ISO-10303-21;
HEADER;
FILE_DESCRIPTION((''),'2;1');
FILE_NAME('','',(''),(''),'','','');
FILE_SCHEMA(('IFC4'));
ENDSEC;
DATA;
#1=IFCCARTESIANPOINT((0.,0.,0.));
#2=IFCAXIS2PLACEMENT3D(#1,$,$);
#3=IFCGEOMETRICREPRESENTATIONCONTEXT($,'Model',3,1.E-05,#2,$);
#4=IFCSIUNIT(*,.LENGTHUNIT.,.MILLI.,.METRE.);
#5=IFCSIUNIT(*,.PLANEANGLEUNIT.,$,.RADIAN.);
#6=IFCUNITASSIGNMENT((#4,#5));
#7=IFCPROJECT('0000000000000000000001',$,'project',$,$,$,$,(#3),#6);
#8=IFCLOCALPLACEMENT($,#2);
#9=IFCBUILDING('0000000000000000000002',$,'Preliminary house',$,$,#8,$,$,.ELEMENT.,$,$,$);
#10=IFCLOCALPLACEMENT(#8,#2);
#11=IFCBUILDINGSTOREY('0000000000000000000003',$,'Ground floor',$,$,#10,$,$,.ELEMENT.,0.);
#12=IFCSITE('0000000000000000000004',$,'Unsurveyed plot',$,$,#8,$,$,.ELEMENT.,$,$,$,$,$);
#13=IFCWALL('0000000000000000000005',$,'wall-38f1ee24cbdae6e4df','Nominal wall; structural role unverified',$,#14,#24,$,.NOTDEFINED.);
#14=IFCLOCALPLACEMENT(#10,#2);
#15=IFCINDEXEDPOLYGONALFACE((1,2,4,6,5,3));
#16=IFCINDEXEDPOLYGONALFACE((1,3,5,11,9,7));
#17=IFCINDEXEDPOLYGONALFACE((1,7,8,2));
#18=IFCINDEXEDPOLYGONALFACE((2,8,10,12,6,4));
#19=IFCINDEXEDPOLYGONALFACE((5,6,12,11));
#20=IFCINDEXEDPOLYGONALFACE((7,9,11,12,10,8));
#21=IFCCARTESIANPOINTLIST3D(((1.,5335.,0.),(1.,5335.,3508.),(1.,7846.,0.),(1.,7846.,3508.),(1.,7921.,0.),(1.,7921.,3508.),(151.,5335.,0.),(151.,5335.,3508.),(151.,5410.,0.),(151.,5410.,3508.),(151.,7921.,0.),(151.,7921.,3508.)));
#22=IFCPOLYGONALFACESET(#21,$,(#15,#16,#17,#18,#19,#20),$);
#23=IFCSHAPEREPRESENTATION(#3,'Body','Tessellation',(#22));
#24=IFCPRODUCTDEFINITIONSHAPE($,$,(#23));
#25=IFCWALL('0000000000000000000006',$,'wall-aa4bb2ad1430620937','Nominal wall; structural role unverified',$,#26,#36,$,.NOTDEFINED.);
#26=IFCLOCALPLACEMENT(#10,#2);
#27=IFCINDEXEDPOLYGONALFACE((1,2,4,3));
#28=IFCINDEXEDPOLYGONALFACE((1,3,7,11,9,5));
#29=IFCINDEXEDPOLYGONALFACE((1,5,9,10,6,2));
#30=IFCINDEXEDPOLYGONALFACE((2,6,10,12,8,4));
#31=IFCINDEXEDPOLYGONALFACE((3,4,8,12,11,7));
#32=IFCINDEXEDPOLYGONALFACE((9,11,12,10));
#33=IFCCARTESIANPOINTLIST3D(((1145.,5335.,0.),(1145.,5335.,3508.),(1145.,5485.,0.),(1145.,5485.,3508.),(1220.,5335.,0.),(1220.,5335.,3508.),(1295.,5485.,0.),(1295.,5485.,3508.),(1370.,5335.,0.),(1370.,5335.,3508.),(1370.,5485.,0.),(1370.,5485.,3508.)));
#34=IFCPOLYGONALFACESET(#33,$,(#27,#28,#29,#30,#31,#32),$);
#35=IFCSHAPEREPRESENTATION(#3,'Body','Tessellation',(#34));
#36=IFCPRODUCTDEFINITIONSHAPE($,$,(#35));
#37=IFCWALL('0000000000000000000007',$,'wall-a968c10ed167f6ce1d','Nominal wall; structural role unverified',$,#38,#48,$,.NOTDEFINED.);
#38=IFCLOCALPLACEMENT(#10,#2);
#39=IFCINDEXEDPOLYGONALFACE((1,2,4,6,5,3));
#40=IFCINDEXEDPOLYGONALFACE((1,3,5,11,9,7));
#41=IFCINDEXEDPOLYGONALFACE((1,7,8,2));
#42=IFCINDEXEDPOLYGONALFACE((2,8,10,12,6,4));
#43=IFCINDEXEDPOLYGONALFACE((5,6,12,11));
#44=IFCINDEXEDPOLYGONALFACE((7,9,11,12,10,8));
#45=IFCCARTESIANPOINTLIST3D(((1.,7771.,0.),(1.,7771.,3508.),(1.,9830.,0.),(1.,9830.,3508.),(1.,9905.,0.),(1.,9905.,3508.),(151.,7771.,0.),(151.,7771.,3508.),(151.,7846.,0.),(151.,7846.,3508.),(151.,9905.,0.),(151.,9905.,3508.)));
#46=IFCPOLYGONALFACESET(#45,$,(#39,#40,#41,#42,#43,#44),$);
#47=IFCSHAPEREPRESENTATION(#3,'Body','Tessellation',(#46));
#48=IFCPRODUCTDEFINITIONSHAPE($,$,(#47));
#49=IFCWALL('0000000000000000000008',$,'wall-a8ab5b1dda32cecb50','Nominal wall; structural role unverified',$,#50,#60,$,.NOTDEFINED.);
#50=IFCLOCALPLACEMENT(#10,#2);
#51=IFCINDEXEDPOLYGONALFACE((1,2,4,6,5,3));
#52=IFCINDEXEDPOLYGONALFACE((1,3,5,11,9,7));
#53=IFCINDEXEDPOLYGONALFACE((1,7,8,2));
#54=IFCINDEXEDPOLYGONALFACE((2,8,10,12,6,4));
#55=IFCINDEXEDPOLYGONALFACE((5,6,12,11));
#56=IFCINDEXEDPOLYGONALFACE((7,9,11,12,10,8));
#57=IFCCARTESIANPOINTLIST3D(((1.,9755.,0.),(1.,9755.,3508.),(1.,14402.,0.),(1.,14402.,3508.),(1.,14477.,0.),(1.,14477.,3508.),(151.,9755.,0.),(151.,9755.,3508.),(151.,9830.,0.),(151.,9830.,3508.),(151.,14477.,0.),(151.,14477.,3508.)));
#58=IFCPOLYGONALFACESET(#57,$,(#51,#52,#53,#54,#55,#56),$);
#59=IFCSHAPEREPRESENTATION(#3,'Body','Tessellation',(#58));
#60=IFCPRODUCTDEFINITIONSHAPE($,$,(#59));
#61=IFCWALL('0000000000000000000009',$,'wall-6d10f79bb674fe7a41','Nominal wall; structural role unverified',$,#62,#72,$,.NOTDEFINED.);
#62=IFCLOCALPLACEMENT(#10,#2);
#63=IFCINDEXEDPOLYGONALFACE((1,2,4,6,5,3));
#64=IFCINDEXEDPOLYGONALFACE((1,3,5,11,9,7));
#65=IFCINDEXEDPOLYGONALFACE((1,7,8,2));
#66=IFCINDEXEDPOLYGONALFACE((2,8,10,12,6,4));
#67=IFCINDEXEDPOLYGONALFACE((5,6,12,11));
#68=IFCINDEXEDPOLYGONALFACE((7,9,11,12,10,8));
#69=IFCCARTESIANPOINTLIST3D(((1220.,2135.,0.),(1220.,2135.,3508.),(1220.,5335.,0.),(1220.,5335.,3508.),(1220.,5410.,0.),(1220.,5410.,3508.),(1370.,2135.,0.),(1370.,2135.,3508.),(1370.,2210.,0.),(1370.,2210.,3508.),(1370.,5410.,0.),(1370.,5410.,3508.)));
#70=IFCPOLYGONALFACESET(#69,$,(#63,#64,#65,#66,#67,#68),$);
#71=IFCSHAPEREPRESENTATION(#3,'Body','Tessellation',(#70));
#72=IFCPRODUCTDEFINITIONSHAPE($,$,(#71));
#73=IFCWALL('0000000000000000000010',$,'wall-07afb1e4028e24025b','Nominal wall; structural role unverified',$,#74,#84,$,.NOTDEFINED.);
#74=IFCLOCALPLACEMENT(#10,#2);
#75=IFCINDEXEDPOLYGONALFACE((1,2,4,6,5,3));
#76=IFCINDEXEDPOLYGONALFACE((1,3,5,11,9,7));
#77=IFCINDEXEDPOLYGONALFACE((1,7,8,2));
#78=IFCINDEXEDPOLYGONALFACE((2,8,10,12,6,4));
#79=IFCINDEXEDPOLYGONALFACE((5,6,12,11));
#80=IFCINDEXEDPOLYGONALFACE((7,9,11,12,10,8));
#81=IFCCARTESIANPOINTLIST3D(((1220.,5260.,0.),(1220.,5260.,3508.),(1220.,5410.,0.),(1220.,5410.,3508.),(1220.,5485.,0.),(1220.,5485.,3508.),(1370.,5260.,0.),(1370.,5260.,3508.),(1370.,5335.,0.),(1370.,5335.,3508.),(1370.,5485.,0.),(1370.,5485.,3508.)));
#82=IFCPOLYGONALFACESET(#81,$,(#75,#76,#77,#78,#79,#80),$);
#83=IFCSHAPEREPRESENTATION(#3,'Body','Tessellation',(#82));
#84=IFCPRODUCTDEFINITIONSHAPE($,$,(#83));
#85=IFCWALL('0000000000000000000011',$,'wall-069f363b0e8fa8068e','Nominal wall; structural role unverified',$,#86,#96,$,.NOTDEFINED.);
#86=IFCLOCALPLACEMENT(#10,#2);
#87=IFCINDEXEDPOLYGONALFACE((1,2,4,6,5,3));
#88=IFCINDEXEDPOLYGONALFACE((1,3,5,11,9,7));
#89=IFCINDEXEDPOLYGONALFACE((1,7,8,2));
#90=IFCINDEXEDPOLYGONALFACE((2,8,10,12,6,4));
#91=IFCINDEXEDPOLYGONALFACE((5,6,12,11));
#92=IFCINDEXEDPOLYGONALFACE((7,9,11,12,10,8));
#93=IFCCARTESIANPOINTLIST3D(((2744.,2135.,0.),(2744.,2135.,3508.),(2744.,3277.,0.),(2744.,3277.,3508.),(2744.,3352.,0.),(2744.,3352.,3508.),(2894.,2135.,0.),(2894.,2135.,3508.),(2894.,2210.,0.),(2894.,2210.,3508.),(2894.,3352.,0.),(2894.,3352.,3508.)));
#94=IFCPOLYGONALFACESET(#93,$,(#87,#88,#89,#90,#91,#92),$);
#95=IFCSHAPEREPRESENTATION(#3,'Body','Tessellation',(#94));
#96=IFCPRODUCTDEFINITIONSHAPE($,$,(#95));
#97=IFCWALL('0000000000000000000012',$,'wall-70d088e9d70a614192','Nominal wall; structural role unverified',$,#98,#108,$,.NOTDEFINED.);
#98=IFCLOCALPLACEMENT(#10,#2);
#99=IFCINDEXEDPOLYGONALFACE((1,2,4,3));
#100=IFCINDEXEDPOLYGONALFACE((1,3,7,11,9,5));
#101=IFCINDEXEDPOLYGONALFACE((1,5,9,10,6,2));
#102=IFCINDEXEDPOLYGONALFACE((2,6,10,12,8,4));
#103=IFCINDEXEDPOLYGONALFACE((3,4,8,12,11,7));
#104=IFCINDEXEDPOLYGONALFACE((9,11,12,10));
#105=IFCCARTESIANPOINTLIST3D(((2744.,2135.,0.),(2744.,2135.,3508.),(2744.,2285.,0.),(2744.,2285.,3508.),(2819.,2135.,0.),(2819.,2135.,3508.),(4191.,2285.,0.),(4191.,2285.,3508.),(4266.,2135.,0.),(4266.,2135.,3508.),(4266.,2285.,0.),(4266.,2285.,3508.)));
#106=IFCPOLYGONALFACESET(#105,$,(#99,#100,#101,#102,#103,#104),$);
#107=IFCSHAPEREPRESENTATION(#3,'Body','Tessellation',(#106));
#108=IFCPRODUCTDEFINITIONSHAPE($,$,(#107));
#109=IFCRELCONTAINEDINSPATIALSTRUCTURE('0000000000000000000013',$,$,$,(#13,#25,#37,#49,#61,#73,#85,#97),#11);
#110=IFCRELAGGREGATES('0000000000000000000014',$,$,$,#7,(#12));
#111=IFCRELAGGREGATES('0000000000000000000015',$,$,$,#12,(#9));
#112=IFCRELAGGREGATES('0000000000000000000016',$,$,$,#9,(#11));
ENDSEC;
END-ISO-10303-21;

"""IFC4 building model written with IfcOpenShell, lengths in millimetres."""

from ifc_helpers import new_model, si_unit, origin, place, context, project, spatial, polyline, outline, extrude, element, save


model = new_model("IFC4")

# Units and contexts
model_context = context("Model", 3, precision=1e-05, world=origin())
ifc_project = project(units=[si_unit("LENGTHUNIT", "METRE", prefix="MILLI"), si_unit("PLANEANGLEUNIT", "RADIAN")], contexts=[model_context])

# Site, building, storey
placement_1 = place(None, origin())
site = spatial("IfcSite", under=ifc_project, at=placement_1, Name="Unsurveyed plot", CompositionType="ELEMENT")
building = spatial("IfcBuilding", under=site, at=placement_1, Name="Preliminary house", CompositionType="ELEMENT")
placement_2 = place(placement_1, origin())
storey = spatial("IfcBuildingStorey", under=building, at=placement_2, Name="Ground floor", CompositionType="ELEMENT", Elevation=0.0)

# Wall
element("IfcWall", 1, at=placement_2, inside=storey, Name="wall-38f1ee24cbdae6e4df", Description="Nominal wall; structural role unverified", PredefinedType="NOTDEFINED", context=model_context, shape_type="SweptSolid", body=[
    extrude(outline(polyline([(1.0, 7846.0), (1.0, 7921.0), (151.0, 7921.0), (151.0, 5410.0), (151.0, 5335.0), (1.0, 5335.0), (1.0, 7846.0)])), origin(), (0.0, 0.0, 1.0), 3508.0),
])

# Walls
element("IfcWall", 2, at=placement_2, inside=storey, Name="wall-aa4bb2ad1430620937", Description="Nominal wall; structural role unverified", PredefinedType="NOTDEFINED", context=model_context, shape_type="SweptSolid", body=[
    extrude(outline(polyline([(1295.0, 5485.0), (1370.0, 5485.0), (1370.0, 5335.0), (1220.0, 5335.0), (1145.0, 5335.0), (1145.0, 5485.0), (1295.0, 5485.0)])), origin(), (0.0, 0.0, 1.0), 3508.0),
])
element("IfcWall", 3, at=placement_2, inside=storey, Name="wall-a968c10ed167f6ce1d", Description="Nominal wall; structural role unverified", PredefinedType="NOTDEFINED", context=model_context, shape_type="SweptSolid", body=[
    extrude(outline(polyline([(1.0, 9830.0), (1.0, 9905.0), (151.0, 9905.0), (151.0, 7846.0), (151.0, 7771.0), (1.0, 7771.0), (1.0, 9830.0)])), origin(), (0.0, 0.0, 1.0), 3508.0),
])

# Wall
element("IfcWall", 4, at=placement_2, inside=storey, Name="wall-a8ab5b1dda32cecb50", Description="Nominal wall; structural role unverified", PredefinedType="NOTDEFINED", context=model_context, shape_type="SweptSolid", body=[
    extrude(outline(polyline([(1.0, 14402.0), (1.0, 14477.0), (151.0, 14477.0), (151.0, 9830.0), (151.0, 9755.0), (1.0, 9755.0), (1.0, 14402.0)])), origin(), (0.0, 0.0, 1.0), 3508.0),
])

# Walls
element("IfcWall", 5, at=placement_2, inside=storey, Name="wall-6d10f79bb674fe7a41", Description="Nominal wall; structural role unverified", PredefinedType="NOTDEFINED", context=model_context, shape_type="SweptSolid", body=[
    extrude(outline(polyline([(1220.0, 5335.0), (1220.0, 5410.0), (1370.0, 5410.0), (1370.0, 2210.0), (1370.0, 2135.0), (1220.0, 2135.0), (1220.0, 5335.0)])), origin(), (0.0, 0.0, 1.0), 3508.0),
])
element("IfcWall", 6, at=placement_2, inside=storey, Name="wall-07afb1e4028e24025b", Description="Nominal wall; structural role unverified", PredefinedType="NOTDEFINED", context=model_context, shape_type="SweptSolid", body=[
    extrude(outline(polyline([(1220.0, 5410.0), (1220.0, 5485.0), (1370.0, 5485.0), (1370.0, 5335.0), (1370.0, 5260.0), (1220.0, 5260.0), (1220.0, 5410.0)])), origin(), (0.0, 0.0, 1.0), 3508.0),
])

# Walls
element("IfcWall", 7, at=placement_2, inside=storey, Name="wall-069f363b0e8fa8068e", Description="Nominal wall; structural role unverified", PredefinedType="NOTDEFINED", context=model_context, shape_type="SweptSolid", body=[
    extrude(outline(polyline([(2744.0, 3277.0), (2744.0, 3352.0), (2894.0, 3352.0), (2894.0, 2210.0), (2894.0, 2135.0), (2744.0, 2135.0), (2744.0, 3277.0)])), origin(), (0.0, 0.0, 1.0), 3508.0),
])
element("IfcWall", 8, at=placement_2, inside=storey, Name="wall-70d088e9d70a614192", Description="Nominal wall; structural role unverified", PredefinedType="NOTDEFINED", context=model_context, shape_type="SweptSolid", body=[
    extrude(outline(polyline([(4191.0, 2285.0), (4266.0, 2285.0), (4266.0, 2135.0), (2819.0, 2135.0), (2744.0, 2135.0), (2744.0, 2285.0), (4191.0, 2285.0)])), origin(), (0.0, 0.0, 1.0), 3508.0),
])

save(model, "model.ifc")
